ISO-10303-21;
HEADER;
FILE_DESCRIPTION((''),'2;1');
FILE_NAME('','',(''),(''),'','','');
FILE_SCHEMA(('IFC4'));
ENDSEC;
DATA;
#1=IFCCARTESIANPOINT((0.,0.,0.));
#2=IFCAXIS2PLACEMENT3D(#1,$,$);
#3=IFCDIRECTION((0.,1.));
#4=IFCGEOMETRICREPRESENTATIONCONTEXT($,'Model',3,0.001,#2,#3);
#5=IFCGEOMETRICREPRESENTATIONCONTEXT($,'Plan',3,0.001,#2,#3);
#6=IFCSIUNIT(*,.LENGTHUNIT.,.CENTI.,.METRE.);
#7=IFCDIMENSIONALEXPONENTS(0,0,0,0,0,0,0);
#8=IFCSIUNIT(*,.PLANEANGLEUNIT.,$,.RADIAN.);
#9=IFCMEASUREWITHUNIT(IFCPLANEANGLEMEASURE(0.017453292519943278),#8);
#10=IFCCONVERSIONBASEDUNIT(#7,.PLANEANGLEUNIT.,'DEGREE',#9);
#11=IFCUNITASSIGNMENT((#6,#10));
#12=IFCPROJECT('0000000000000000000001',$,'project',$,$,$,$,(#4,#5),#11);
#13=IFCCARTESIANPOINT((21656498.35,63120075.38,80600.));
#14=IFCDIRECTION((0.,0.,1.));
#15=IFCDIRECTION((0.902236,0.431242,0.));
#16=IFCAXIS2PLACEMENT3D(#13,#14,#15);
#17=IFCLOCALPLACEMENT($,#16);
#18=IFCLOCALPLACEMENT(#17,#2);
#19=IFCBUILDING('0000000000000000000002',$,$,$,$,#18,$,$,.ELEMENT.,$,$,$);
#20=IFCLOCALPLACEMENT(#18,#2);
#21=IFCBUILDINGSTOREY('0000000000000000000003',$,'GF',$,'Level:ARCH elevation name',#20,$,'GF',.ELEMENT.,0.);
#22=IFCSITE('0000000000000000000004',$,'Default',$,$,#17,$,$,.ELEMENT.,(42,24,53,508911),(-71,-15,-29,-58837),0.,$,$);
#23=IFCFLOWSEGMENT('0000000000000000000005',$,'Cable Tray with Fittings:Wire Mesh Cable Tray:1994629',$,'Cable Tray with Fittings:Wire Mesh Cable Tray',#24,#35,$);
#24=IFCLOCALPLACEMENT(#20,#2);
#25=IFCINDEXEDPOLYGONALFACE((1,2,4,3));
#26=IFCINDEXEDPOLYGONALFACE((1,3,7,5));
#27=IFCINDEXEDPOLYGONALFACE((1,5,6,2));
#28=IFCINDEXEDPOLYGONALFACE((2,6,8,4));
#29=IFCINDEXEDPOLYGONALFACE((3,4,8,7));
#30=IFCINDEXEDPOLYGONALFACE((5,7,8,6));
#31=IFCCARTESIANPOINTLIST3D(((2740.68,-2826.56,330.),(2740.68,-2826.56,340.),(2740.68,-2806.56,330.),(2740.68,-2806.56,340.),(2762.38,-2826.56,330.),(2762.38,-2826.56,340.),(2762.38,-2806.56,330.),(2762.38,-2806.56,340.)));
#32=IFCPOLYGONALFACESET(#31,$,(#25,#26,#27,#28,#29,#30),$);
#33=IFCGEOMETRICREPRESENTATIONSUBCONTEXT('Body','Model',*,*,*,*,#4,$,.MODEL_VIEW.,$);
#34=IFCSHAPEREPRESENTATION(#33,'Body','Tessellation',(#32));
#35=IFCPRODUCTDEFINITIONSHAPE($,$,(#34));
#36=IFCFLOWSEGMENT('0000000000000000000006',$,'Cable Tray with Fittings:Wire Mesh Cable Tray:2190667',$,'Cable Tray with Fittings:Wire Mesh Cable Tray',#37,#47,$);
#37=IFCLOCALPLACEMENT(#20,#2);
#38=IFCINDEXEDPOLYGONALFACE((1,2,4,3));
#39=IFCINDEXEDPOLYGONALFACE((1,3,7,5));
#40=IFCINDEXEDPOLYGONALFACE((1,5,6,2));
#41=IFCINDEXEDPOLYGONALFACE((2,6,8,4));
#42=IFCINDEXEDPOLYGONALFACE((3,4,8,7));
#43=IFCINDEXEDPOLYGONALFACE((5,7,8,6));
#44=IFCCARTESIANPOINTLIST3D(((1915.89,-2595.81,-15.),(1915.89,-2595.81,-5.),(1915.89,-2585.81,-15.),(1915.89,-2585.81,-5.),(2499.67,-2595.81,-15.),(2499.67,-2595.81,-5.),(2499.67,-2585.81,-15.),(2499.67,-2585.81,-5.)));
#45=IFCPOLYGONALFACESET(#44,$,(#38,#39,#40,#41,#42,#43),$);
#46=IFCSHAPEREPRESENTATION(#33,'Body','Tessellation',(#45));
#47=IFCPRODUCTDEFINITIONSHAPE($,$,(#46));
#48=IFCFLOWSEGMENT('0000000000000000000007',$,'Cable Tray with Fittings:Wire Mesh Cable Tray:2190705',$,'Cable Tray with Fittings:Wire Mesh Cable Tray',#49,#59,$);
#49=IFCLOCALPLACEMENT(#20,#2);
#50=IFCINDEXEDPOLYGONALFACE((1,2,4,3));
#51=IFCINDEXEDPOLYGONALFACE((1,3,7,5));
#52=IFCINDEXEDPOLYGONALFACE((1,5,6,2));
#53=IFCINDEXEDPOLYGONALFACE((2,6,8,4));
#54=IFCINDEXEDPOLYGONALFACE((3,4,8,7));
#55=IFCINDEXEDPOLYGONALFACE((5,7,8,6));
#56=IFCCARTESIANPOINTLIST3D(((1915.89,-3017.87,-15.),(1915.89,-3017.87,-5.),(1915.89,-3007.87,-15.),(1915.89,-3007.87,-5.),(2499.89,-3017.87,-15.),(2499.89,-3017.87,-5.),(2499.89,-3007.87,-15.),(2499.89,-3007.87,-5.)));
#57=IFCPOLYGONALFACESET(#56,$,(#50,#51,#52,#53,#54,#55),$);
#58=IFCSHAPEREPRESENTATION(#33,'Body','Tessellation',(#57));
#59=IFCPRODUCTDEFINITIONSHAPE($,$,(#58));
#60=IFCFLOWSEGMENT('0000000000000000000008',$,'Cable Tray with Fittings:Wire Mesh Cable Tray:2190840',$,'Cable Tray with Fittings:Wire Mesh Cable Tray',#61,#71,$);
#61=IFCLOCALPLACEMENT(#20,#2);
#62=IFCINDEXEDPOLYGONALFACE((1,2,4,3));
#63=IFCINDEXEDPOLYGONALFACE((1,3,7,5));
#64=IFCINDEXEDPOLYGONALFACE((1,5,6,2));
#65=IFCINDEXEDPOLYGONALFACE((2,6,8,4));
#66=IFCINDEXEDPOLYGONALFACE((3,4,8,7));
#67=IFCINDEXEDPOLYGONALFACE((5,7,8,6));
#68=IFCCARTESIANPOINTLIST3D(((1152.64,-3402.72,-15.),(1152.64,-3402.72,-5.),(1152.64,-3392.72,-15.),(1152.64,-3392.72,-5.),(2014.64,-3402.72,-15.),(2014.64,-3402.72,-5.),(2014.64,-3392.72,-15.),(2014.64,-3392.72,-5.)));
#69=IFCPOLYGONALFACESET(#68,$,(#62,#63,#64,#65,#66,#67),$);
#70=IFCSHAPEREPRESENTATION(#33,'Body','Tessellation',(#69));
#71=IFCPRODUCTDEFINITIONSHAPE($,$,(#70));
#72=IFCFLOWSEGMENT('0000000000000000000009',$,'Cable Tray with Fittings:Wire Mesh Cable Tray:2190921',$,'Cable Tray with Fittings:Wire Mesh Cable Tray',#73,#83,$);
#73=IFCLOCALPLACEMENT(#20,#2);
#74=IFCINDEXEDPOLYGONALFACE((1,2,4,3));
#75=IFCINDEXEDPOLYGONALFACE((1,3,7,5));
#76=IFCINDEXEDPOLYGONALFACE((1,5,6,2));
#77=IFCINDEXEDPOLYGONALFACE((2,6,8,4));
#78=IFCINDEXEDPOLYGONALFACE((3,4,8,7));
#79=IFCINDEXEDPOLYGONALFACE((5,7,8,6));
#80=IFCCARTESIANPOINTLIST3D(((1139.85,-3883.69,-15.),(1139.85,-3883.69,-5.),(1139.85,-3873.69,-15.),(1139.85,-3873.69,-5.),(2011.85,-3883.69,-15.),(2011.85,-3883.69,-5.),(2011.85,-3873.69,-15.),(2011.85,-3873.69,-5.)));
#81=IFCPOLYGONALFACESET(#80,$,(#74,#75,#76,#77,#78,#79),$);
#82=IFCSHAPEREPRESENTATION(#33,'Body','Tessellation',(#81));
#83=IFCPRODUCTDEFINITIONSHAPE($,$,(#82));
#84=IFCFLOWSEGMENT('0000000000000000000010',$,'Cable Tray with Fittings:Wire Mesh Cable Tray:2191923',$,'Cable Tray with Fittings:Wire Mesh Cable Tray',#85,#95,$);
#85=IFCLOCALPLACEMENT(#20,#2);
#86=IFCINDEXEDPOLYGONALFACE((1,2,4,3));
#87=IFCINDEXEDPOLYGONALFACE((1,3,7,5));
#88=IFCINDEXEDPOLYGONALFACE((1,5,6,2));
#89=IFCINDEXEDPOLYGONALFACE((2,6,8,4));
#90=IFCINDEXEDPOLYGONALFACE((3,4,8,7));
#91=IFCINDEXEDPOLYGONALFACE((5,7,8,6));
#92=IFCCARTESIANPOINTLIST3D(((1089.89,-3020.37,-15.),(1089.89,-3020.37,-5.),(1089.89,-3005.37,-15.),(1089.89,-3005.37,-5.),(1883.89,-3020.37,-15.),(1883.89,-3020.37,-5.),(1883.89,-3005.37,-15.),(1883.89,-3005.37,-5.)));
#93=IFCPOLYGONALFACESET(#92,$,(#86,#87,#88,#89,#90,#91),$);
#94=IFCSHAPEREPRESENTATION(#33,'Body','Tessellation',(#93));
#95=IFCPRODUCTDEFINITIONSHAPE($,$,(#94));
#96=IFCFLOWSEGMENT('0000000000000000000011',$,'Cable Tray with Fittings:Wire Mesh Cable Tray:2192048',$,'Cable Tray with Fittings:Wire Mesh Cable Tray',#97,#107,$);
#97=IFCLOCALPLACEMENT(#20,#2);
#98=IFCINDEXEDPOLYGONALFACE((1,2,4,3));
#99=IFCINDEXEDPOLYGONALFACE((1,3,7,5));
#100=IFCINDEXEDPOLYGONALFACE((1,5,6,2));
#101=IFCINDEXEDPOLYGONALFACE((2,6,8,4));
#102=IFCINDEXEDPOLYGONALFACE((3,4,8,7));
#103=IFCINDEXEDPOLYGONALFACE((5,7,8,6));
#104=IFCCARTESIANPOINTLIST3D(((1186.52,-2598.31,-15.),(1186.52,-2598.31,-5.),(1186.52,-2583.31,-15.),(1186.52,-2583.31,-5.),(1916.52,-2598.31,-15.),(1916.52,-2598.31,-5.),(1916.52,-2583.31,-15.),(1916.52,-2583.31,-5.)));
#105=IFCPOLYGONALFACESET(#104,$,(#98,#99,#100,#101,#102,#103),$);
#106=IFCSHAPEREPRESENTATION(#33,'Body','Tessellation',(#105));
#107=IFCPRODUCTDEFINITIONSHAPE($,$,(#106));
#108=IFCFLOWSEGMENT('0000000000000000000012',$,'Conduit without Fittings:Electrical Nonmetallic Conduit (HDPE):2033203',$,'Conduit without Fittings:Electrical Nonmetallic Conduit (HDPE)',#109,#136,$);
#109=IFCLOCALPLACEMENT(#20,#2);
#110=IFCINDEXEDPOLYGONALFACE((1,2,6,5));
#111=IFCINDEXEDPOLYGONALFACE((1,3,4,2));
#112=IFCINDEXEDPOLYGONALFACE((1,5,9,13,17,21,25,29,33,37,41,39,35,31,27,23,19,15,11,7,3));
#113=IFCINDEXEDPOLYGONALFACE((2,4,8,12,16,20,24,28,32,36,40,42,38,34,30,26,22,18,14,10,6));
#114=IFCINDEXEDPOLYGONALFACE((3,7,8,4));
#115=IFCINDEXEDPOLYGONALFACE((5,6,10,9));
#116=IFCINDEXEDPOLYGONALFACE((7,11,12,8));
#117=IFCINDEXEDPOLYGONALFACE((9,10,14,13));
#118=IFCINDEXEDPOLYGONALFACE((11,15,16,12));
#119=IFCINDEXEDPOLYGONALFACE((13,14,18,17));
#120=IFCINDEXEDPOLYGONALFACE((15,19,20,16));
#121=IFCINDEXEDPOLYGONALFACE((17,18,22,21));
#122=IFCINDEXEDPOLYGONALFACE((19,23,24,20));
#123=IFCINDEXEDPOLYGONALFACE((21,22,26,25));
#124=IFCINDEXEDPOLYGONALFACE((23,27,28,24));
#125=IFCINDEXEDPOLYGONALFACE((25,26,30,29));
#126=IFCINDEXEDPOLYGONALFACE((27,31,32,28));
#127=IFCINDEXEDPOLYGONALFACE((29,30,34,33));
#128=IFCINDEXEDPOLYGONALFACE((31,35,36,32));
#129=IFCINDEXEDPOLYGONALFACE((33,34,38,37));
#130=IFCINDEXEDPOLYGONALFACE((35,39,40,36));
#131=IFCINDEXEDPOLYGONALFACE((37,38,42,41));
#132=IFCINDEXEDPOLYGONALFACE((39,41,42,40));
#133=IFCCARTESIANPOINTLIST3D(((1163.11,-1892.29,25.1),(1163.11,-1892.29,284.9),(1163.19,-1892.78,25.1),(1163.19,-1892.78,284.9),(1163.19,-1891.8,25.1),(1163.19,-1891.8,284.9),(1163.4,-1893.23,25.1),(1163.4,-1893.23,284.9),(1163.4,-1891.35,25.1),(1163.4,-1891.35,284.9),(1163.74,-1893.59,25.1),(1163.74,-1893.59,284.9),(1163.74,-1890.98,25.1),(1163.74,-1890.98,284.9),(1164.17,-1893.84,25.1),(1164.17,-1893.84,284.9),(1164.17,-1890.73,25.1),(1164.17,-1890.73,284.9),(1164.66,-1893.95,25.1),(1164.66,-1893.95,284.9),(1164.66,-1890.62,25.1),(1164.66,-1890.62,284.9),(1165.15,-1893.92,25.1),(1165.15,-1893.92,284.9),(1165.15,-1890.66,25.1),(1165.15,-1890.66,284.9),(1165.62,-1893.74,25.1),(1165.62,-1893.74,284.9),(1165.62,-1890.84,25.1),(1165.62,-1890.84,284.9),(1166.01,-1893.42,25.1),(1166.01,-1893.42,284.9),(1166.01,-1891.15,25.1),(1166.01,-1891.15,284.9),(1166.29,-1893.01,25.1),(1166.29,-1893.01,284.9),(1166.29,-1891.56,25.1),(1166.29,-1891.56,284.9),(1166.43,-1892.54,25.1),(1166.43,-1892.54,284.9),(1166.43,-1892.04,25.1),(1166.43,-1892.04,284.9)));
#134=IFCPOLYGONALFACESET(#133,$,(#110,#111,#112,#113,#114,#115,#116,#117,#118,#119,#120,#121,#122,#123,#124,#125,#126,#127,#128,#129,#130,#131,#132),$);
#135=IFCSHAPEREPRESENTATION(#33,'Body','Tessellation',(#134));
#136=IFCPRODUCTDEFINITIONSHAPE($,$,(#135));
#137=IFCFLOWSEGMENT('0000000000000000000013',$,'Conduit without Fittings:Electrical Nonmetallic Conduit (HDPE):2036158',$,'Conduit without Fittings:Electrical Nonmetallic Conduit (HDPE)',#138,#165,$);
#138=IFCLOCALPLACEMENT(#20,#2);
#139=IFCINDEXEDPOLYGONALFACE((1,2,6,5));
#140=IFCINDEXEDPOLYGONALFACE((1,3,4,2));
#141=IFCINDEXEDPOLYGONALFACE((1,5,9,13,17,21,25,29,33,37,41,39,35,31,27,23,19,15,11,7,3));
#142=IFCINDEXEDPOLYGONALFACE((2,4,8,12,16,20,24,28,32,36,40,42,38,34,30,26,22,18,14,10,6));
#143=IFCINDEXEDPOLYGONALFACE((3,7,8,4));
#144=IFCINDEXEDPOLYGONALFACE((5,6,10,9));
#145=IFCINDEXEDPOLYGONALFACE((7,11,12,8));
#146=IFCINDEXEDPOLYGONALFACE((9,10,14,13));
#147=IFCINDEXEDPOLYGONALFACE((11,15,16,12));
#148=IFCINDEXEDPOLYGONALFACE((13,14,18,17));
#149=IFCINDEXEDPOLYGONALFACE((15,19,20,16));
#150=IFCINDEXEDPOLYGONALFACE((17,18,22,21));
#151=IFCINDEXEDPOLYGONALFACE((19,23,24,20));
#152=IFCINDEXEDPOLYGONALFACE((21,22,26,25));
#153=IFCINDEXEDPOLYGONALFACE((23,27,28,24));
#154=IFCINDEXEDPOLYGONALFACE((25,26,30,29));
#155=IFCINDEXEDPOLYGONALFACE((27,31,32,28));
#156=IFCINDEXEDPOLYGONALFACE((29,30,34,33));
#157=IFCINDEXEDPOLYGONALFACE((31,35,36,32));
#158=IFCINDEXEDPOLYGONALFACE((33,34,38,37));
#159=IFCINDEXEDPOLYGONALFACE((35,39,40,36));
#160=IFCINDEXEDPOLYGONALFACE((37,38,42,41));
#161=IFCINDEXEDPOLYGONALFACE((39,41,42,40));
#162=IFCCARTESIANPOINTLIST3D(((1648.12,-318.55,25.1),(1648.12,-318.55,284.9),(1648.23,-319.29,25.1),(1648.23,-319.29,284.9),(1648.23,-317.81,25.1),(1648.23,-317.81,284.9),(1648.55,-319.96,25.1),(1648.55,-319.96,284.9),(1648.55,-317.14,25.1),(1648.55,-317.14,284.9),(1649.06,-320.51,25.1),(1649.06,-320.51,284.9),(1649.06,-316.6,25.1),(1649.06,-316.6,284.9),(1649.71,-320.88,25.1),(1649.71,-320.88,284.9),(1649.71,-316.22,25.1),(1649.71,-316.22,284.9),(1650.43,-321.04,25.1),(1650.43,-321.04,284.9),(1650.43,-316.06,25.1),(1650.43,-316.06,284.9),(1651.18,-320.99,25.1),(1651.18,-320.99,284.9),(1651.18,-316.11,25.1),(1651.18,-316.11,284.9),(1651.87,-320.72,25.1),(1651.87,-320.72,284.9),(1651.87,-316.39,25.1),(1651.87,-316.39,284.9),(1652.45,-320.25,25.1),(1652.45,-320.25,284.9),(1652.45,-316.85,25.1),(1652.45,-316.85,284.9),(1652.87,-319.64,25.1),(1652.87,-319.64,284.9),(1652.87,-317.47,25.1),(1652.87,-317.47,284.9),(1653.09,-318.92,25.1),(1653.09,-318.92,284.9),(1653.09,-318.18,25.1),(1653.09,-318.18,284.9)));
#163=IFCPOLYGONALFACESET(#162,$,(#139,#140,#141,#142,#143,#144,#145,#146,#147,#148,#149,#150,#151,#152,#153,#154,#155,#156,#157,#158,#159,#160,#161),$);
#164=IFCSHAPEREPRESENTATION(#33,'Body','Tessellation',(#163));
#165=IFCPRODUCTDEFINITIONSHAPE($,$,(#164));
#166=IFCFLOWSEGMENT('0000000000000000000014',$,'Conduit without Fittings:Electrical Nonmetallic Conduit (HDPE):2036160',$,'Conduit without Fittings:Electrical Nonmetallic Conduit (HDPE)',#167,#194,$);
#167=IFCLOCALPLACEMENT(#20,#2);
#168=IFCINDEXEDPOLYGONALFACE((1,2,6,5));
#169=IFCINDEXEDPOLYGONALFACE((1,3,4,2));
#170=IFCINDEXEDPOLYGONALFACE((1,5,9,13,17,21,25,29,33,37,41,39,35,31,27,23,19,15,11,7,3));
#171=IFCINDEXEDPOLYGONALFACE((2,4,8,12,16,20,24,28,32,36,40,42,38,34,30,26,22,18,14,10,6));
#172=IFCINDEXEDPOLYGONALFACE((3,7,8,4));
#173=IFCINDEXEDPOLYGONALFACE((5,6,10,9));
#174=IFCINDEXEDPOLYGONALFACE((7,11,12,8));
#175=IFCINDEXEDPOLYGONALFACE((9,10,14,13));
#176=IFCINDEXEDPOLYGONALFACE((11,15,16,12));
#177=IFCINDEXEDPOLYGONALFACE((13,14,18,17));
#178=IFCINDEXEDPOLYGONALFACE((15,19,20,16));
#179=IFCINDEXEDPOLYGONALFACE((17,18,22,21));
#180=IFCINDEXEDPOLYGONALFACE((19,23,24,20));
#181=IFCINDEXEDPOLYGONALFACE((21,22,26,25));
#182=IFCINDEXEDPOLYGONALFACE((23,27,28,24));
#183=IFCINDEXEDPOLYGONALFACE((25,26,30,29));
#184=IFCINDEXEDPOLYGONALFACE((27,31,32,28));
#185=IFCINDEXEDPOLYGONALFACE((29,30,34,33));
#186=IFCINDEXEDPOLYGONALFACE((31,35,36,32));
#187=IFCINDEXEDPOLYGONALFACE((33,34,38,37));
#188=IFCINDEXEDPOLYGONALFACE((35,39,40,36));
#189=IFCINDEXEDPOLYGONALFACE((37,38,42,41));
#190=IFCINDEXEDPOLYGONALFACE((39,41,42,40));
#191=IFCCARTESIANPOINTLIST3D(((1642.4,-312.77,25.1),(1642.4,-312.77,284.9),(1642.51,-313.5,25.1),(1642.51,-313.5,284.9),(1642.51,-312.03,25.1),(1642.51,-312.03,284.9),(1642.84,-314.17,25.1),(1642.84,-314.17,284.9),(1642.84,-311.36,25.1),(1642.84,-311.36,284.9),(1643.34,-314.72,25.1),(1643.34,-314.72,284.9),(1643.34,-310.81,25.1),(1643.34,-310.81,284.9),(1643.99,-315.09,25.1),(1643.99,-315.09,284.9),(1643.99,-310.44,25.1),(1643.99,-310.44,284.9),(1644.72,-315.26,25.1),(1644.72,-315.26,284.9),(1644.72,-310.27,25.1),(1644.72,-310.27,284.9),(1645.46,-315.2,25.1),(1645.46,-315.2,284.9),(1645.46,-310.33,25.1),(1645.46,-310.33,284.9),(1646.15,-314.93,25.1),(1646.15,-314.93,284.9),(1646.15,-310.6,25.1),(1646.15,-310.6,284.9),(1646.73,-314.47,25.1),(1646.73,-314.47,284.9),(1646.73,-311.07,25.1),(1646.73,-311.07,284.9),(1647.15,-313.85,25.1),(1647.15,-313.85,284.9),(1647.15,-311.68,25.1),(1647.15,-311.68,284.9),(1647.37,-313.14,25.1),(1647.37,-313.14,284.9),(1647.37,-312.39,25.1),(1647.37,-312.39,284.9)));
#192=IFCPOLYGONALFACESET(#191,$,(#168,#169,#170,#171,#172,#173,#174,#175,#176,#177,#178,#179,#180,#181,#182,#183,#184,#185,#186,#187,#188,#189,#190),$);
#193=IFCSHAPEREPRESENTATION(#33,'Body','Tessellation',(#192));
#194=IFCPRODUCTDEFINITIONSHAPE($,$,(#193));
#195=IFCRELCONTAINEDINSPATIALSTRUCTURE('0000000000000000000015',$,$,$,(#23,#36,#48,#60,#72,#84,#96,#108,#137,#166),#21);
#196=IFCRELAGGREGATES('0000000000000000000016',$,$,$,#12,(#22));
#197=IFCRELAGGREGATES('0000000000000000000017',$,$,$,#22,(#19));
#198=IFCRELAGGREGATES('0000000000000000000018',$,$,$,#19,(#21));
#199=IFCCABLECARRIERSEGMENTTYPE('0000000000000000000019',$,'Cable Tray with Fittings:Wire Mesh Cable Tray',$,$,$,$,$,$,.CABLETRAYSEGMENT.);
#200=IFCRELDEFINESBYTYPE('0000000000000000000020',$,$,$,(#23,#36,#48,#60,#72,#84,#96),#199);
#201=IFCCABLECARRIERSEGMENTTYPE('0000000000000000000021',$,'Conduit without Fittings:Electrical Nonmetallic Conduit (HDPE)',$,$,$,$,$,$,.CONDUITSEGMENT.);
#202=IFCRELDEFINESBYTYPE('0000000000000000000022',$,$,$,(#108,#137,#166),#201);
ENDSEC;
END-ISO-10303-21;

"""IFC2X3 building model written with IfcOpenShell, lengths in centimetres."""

from ifc_helpers import new_model, entity, si_unit, converted_unit, direction, frame, frame_2d, origin, origin_2d_with_axis, place, context, subcontext, project, spatial, rectangle, circle, extrude, type_object, element, save


model = new_model("IFC2X3")

# Units and contexts
model_context = context("Model", 3, precision=0.001, world=origin(), true_north=direction((0.0, 1.0)))
plan_context = context("Plan", 3, precision=0.001, world=origin(), true_north=direction((0.0, 1.0)))
body_context = subcontext(model_context, "Body", "Model", "MODEL_VIEW")
ifc_project = project(units=[si_unit("LENGTHUNIT", "METRE", prefix="CENTI"), converted_unit("PLANEANGLEUNIT", "DEGREE", entity("IfcPlaneAngleMeasure", 0.017453292519943278), si_unit("PLANEANGLEUNIT", "RADIAN"), dimensions=[0, 0, 0, 0, 0, 0, 0])], contexts=[model_context, plan_context])

# Site, building, storey
site_placement = place(None, frame((21656498.35, 63120075.38, 80600.0), z_axis=(0.0, 0.0, 1.0), x_axis=(0.902236, 0.431242, 0.0)))
site = spatial("IfcSite", under=ifc_project, at=site_placement, Name="Default", CompositionType="ELEMENT", RefLatitude=(42, 24, 53, 508911), RefLongitude=(-71, -15, -29, -58837), RefElevation=0.0)
building_placement = place(site_placement, origin())
building = spatial("IfcBuilding", under=site, at=building_placement, CompositionType="ELEMENT")
storey_placement = place(building_placement, origin())
storey = spatial("IfcBuildingStorey", under=building, at=storey_placement, Name="GF", ObjectType="Level:ARCH elevation name", LongName="GF", CompositionType="ELEMENT", Elevation=0.0)

# Flow segments
cable_carrier_segment_type_1 = type_object("IfcCableCarrierSegmentType", Name="Cable Tray with Fittings:Wire Mesh Cable Tray", PredefinedType="CABLETRAYSEGMENT")
flow_segment_1_placement = place(storey_placement, origin())
element("IfcFlowSegment", 1, at=flow_segment_1_placement, inside=storey, type_object=cable_carrier_segment_type_1, Name="Cable Tray with Fittings:Wire Mesh Cable Tray:1994629", ObjectType="Cable Tray with Fittings:Wire Mesh Cable Tray", context=body_context, shape_type="SweptSolid", body=[
    extrude(rectangle(XDim=21.7, YDim=20.0, at=frame_2d((0.0, 0.0), x_axis=(1.0, 0.0))), frame((2751.53, -2816.56, 330.0), z_axis=(0.0, 0.0, 1.0), x_axis=(-1.0, 0.0, 0.0)), (0.0, 0.0, 1.0), 10.0),
])
flow_segment_2_placement = place(storey_placement, origin())
element("IfcFlowSegment", 2, at=flow_segment_2_placement, inside=storey, type_object=cable_carrier_segment_type_1, Name="Cable Tray with Fittings:Wire Mesh Cable Tray:2190667", ObjectType="Cable Tray with Fittings:Wire Mesh Cable Tray", context=body_context, shape_type="SweptSolid", body=[
    extrude(rectangle(XDim=583.79, YDim=10.0, at=frame_2d((0.0, 0.0), x_axis=(1.0, 0.0))), frame((2207.78, -2590.81, -15.0)), (0.0, 0.0, 1.0), 10.0),
])
flow_segment_3_placement = place(storey_placement, origin())
element("IfcFlowSegment", 3, at=flow_segment_3_placement, inside=storey, type_object=cable_carrier_segment_type_1, Name="Cable Tray with Fittings:Wire Mesh Cable Tray:2190705", ObjectType="Cable Tray with Fittings:Wire Mesh Cable Tray", context=body_context, shape_type="SweptSolid", body=[
    extrude(rectangle(XDim=584.0, YDim=10.0, at=frame_2d((0.0, 0.0), x_axis=(1.0, 0.0))), frame((2207.89, -3012.87, -15.0)), (0.0, 0.0, 1.0), 10.0),
])
flow_segment_4_placement = place(storey_placement, origin())
element("IfcFlowSegment", 4, at=flow_segment_4_placement, inside=storey, type_object=cable_carrier_segment_type_1, Name="Cable Tray with Fittings:Wire Mesh Cable Tray:2190840", ObjectType="Cable Tray with Fittings:Wire Mesh Cable Tray", context=body_context, shape_type="SweptSolid", body=[
    extrude(rectangle(XDim=862.0, YDim=10.0, at=frame_2d((0.0, 0.0), x_axis=(1.0, 0.0))), frame((1583.64, -3397.72, -15.0)), (0.0, 0.0, 1.0), 10.0),
])
flow_segment_5_placement = place(storey_placement, origin())
element("IfcFlowSegment", 5, at=flow_segment_5_placement, inside=storey, type_object=cable_carrier_segment_type_1, Name="Cable Tray with Fittings:Wire Mesh Cable Tray:2190921", ObjectType="Cable Tray with Fittings:Wire Mesh Cable Tray", context=body_context, shape_type="SweptSolid", body=[
    extrude(rectangle(XDim=872.0, YDim=10.0, at=frame_2d((0.0, 0.0), x_axis=(1.0, 0.0))), frame((1575.85, -3878.69, -15.0)), (0.0, 0.0, 1.0), 10.0),
])
flow_segment_6_placement = place(storey_placement, origin())
element("IfcFlowSegment", 6, at=flow_segment_6_placement, inside=storey, type_object=cable_carrier_segment_type_1, Name="Cable Tray with Fittings:Wire Mesh Cable Tray:2191923", ObjectType="Cable Tray with Fittings:Wire Mesh Cable Tray", context=body_context, shape_type="SweptSolid", body=[
    extrude(rectangle(XDim=794.0, YDim=15.0, at=origin_2d_with_axis()), frame((1486.89, -3012.87, -15.0)), (0.0, 0.0, 1.0), 10.0),
])
flow_segment_7_placement = place(storey_placement, origin())
element("IfcFlowSegment", 7, at=flow_segment_7_placement, inside=storey, type_object=cable_carrier_segment_type_1, Name="Cable Tray with Fittings:Wire Mesh Cable Tray:2192048", ObjectType="Cable Tray with Fittings:Wire Mesh Cable Tray", context=body_context, shape_type="SweptSolid", body=[
    extrude(rectangle(XDim=730.0, YDim=15.0, at=frame_2d((0.0, 0.0), x_axis=(1.0, 0.0))), frame((1551.52, -2590.81, -15.0)), (0.0, 0.0, 1.0), 10.0),
])
cable_carrier_segment_type_2 = type_object("IfcCableCarrierSegmentType", Name="Conduit without Fittings:Electrical Nonmetallic Conduit (HDPE)", PredefinedType="CONDUITSEGMENT")
flow_segment_8_placement = place(storey_placement, origin())
element("IfcFlowSegment", 8, at=flow_segment_8_placement, inside=storey, type_object=cable_carrier_segment_type_2, Name="Conduit without Fittings:Electrical Nonmetallic Conduit (HDPE):2033203", ObjectType="Conduit without Fittings:Electrical Nonmetallic Conduit (HDPE)", context=body_context, shape_type="SweptSolid", body=[
    extrude(circle(Radius=1.67, at=origin_2d_with_axis()), frame((1164.78, -1892.29, 25.1), z_axis=(0.0, 0.0, 1.0), x_axis=(-1.0, 0.0, 0.0)), (0.0, 0.0, 1.0), 259.8),
])
flow_segment_9_placement = place(storey_placement, origin())
element("IfcFlowSegment", 9, at=flow_segment_9_placement, inside=storey, type_object=cable_carrier_segment_type_2, Name="Conduit without Fittings:Electrical Nonmetallic Conduit (HDPE):2036158", ObjectType="Conduit without Fittings:Electrical Nonmetallic Conduit (HDPE)", context=body_context, shape_type="SweptSolid", body=[
    extrude(circle(Radius=2.5, at=frame_2d((0.0, 0.0), x_axis=(1.0, 0.0))), frame((1650.62, -318.55, 25.1), z_axis=(0.0, 0.0, 1.0), x_axis=(-1.0, 0.0, 0.0)), (0.0, 0.0, 1.0), 259.8),
])
flow_segment_10_placement = place(storey_placement, origin())
element("IfcFlowSegment", 10, at=flow_segment_10_placement, inside=storey, type_object=cable_carrier_segment_type_2, Name="Conduit without Fittings:Electrical Nonmetallic Conduit (HDPE):2036160", ObjectType="Conduit without Fittings:Electrical Nonmetallic Conduit (HDPE)", context=body_context, shape_type="SweptSolid", body=[
    extrude(circle(Radius=2.5, at=origin_2d_with_axis()), frame((1644.9, -312.77, 25.1), z_axis=(0.0, 0.0, 1.0), x_axis=(-1.0, 0.0, 0.0)), (0.0, 0.0, 1.0), 259.8),
])

save(model, "model.ifc")
